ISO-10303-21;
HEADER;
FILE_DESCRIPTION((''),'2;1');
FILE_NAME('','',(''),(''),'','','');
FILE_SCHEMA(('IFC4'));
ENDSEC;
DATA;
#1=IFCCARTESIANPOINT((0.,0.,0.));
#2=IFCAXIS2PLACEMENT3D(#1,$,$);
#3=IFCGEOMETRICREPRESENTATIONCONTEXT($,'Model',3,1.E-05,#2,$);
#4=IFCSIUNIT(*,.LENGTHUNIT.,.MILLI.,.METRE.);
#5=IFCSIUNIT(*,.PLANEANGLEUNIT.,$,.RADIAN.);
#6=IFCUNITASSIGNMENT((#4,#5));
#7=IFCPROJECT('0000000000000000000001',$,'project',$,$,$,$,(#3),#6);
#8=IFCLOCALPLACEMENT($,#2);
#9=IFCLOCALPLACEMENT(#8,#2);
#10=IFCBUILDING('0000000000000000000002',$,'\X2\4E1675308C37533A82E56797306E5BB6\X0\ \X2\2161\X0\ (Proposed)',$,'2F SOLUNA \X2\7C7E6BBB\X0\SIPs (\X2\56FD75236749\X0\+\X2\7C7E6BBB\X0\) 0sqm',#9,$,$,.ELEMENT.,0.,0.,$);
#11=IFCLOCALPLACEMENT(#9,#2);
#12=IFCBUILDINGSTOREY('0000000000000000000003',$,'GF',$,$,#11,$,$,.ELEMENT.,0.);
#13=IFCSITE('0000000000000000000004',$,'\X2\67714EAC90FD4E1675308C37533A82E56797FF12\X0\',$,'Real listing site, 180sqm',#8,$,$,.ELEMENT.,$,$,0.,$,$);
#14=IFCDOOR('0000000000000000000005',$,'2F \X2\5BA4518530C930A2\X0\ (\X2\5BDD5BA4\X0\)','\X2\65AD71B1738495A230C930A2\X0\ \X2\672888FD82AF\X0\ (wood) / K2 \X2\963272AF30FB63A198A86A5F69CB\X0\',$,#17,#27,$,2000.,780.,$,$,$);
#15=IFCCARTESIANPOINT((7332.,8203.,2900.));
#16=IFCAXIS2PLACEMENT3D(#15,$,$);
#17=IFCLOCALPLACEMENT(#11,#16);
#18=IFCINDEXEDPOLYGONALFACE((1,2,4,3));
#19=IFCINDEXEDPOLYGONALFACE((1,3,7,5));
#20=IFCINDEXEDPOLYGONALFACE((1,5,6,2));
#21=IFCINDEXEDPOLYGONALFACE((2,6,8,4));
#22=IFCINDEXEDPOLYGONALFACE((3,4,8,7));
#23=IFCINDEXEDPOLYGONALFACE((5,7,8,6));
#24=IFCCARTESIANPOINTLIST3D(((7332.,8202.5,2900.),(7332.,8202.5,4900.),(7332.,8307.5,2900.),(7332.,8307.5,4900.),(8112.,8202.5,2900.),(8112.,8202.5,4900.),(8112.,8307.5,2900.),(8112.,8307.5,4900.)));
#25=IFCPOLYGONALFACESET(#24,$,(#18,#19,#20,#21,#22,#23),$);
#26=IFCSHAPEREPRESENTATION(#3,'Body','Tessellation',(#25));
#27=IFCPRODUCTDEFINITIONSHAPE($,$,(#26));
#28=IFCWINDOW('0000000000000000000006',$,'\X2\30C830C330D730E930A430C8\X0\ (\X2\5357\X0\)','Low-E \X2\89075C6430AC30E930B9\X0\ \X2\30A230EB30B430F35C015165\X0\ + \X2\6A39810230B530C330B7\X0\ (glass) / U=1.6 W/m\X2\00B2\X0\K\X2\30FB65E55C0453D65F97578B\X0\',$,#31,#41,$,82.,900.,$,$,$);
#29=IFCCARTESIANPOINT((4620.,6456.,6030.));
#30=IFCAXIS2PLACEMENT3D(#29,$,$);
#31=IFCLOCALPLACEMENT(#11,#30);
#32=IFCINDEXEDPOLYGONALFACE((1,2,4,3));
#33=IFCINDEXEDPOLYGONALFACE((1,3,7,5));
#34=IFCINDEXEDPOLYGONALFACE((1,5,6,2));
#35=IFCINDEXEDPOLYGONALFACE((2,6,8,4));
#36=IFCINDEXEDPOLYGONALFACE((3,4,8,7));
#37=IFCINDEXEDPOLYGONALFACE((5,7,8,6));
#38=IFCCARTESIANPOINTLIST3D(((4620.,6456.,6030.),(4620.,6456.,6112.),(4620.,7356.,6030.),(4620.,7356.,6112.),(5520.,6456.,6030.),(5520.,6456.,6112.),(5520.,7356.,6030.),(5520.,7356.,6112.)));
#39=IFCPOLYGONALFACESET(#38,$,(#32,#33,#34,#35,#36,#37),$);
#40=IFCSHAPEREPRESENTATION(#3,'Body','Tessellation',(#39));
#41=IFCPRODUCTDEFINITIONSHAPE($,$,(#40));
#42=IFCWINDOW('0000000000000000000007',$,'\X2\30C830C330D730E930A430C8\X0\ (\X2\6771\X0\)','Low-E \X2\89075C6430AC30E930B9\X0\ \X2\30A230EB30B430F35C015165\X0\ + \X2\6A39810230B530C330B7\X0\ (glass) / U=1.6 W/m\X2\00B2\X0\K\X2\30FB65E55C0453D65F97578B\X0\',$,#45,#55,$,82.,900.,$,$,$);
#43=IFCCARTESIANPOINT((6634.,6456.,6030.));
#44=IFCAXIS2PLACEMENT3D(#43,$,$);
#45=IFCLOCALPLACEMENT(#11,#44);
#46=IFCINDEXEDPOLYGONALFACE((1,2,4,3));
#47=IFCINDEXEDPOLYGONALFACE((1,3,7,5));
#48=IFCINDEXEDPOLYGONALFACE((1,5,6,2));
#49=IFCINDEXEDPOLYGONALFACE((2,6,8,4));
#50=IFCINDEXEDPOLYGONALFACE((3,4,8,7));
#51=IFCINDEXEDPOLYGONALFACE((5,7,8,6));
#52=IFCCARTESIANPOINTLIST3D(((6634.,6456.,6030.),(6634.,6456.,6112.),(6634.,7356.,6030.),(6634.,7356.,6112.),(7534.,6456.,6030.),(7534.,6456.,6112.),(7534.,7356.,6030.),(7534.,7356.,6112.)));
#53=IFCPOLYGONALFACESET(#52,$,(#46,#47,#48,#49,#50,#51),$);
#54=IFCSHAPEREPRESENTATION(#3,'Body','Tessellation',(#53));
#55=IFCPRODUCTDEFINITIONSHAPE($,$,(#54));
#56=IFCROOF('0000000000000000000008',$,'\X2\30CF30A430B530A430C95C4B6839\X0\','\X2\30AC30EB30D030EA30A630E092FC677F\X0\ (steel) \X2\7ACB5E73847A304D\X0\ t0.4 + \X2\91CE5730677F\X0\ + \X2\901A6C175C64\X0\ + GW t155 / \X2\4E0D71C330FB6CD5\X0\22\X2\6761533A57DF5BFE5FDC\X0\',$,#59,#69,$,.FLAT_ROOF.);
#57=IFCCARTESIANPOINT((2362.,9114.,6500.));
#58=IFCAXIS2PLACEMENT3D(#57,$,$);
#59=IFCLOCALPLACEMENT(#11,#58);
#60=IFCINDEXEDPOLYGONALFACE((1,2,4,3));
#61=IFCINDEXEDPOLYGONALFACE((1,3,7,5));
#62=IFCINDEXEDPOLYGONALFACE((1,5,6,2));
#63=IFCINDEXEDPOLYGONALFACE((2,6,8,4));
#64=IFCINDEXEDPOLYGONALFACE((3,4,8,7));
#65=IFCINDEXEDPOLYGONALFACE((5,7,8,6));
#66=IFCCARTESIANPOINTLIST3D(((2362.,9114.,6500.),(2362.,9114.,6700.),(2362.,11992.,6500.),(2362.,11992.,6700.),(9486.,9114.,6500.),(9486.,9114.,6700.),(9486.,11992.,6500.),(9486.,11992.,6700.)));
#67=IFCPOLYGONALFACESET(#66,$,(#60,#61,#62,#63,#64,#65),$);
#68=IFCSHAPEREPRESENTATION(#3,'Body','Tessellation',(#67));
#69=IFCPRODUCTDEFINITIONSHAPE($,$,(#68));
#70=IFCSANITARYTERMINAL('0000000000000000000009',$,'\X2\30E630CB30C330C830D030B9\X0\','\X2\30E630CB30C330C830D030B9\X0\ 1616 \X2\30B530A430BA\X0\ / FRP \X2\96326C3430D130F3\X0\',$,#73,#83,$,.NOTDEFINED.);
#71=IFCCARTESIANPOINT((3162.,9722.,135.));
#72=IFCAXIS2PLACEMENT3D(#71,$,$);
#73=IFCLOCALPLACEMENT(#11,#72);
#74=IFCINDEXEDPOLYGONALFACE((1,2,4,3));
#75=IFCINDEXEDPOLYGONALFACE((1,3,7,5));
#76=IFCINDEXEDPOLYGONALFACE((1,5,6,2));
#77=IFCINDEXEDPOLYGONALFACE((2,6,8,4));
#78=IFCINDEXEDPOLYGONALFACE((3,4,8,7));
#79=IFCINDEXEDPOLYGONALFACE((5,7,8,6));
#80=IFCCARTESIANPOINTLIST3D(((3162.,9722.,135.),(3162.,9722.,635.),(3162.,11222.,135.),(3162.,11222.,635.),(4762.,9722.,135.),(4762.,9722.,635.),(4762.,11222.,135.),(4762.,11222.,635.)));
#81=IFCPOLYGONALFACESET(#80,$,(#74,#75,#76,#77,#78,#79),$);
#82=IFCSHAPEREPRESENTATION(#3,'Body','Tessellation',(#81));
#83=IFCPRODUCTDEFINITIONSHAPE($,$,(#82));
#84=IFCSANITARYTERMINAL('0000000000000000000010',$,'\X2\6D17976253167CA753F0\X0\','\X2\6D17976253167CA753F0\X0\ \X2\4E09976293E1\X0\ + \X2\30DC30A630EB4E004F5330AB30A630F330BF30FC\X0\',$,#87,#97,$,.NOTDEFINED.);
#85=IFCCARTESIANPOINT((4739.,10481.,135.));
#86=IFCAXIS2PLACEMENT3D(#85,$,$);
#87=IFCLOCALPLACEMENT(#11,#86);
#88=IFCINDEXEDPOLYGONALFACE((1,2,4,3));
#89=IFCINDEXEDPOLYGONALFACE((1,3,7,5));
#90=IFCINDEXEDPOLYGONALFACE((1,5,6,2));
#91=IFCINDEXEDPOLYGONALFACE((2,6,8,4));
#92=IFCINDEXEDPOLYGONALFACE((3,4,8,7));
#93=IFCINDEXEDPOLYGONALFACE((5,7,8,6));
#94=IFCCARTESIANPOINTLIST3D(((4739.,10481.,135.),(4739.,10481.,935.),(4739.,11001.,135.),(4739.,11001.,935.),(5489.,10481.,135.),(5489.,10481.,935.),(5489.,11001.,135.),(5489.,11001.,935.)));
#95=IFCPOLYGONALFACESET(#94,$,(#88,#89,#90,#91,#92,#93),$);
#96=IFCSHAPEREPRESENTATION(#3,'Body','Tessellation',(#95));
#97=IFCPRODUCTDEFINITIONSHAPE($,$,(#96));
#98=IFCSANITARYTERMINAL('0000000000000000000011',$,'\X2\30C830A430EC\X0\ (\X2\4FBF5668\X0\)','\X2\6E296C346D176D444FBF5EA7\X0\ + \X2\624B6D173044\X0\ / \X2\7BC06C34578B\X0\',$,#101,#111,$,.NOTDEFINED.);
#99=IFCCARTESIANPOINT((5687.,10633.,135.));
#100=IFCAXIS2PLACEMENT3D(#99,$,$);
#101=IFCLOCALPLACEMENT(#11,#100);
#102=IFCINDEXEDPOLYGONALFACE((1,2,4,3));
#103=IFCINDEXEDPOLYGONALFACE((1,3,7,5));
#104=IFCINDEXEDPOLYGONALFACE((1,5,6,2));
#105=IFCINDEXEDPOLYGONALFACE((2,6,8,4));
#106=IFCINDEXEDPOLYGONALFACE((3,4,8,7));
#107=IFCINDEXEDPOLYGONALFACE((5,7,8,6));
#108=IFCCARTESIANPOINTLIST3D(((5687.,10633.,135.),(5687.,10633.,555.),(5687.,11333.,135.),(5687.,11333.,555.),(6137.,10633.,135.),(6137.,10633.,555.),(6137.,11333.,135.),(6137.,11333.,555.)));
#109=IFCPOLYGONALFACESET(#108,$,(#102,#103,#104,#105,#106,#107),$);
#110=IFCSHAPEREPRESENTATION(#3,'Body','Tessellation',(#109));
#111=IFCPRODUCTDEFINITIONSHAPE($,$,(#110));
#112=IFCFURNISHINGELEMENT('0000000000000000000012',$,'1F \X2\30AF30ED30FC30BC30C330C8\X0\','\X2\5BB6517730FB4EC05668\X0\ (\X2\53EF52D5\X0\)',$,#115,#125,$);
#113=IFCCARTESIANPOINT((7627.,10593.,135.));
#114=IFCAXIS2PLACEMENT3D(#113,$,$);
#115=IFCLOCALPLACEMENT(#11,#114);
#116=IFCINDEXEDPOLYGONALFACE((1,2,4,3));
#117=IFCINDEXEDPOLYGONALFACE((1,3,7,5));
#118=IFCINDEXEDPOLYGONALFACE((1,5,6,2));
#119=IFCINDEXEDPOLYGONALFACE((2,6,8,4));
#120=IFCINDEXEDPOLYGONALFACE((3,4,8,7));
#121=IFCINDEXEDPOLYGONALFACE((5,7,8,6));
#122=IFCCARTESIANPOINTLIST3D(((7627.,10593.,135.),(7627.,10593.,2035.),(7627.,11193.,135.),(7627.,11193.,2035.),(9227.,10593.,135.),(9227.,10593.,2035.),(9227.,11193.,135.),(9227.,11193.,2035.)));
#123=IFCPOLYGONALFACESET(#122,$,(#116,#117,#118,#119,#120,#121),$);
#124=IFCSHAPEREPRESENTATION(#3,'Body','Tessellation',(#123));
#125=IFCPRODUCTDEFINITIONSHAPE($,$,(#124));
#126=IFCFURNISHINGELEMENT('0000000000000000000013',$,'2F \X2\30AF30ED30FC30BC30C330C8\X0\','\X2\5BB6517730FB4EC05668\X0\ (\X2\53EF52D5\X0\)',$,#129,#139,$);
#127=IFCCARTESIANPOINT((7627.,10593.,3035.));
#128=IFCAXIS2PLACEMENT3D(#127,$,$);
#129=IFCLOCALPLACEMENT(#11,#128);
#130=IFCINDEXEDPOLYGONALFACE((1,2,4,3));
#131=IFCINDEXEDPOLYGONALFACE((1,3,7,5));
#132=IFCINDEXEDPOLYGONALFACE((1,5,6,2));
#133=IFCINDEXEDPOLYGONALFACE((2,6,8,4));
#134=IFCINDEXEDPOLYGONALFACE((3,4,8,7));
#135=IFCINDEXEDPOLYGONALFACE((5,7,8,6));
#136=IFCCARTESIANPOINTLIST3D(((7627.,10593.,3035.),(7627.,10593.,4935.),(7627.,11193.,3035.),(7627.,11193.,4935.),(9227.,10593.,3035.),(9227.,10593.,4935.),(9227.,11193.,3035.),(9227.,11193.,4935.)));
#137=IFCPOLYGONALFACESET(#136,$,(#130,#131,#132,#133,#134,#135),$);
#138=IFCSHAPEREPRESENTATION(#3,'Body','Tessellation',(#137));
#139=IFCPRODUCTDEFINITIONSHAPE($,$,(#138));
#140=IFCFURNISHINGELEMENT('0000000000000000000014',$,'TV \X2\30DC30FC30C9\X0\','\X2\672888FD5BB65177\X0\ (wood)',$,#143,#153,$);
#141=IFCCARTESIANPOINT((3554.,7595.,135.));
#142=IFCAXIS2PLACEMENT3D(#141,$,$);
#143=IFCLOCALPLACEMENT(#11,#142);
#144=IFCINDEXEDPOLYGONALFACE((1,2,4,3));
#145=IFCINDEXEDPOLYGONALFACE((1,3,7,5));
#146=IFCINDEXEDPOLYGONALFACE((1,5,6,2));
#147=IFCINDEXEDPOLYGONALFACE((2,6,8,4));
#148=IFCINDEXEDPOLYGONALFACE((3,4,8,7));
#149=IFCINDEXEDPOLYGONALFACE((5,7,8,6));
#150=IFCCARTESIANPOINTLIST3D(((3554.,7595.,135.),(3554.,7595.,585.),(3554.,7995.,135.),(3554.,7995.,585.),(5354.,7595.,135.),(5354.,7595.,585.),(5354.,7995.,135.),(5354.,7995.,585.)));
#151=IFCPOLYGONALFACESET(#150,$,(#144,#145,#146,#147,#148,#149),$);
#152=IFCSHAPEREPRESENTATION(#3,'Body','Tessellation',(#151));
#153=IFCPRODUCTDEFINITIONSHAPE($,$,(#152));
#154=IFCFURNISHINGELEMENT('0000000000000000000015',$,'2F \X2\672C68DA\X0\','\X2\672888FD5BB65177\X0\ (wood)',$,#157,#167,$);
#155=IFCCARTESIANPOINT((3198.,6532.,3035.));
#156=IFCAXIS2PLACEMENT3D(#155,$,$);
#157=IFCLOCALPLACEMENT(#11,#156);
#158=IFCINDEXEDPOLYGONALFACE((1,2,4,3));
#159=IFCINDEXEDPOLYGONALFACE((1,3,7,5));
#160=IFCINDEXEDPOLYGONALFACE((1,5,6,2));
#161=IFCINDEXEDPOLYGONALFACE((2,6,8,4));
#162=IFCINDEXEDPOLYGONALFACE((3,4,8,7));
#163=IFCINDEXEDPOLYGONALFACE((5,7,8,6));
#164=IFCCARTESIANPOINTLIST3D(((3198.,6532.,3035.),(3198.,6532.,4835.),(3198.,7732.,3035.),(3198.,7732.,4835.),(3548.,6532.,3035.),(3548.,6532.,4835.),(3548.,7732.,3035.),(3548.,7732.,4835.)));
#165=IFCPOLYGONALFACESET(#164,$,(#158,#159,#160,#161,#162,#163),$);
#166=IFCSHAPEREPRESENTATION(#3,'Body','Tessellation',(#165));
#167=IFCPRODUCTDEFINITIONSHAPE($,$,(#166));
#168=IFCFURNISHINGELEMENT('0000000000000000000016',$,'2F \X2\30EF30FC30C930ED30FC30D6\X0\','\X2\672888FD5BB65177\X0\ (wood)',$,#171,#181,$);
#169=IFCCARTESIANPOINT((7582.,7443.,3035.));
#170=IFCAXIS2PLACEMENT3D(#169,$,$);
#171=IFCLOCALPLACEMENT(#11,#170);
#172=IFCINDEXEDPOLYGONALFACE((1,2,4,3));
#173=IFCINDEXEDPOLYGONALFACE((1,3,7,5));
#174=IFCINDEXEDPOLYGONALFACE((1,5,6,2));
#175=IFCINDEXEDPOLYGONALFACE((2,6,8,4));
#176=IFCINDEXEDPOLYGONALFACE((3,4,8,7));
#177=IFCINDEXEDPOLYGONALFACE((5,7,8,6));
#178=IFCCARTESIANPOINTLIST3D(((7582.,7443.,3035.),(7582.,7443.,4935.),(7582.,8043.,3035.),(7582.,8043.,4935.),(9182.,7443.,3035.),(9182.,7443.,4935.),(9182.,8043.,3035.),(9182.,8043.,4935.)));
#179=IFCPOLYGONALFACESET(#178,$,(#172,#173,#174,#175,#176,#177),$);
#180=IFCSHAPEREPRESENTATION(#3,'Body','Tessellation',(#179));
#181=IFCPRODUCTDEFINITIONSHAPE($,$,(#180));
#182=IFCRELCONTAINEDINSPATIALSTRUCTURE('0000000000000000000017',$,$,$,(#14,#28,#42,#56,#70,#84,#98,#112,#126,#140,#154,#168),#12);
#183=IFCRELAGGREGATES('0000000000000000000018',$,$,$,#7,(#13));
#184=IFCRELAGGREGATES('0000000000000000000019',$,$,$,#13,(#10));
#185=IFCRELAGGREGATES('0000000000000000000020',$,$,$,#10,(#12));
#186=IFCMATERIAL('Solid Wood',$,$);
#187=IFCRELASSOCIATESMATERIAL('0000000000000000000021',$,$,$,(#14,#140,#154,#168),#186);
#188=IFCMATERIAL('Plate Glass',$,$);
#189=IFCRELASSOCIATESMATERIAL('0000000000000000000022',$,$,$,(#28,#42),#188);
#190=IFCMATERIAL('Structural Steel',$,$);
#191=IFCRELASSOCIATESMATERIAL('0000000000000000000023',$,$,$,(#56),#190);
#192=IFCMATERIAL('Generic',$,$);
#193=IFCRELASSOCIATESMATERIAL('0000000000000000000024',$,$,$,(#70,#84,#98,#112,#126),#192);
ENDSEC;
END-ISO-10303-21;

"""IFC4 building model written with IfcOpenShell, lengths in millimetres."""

from ifc_helpers import new_model, si_unit, frame, frame_2d, origin, place, context, project, spatial, rectangle, extrude, material, element, save


model = new_model("IFC4")

# Units and contexts
model_context = context("Model", 3, precision=1e-05, world=origin())
ifc_project = project(units=[si_unit("LENGTHUNIT", "METRE", prefix="MILLI"), si_unit("PLANEANGLEUNIT", "RADIAN")], contexts=[model_context])

# Site, building, storey
site_placement = place(None, origin())
site = spatial("IfcSite", under=ifc_project, at=site_placement, Name="東京都世田谷区若林２", ObjectType="Real listing site, 180sqm", CompositionType="ELEMENT", RefElevation=0.0)
building_placement = place(site_placement, origin())
building = spatial("IfcBuilding", under=site, at=building_placement, Name="世田谷区若林の家 Ⅱ (Proposed)", ObjectType="2F SOLUNA 籾殻SIPs (国産杉+籾殻) 0sqm", CompositionType="ELEMENT", ElevationOfRefHeight=0.0, ElevationOfTerrain=0.0)
storey_placement = place(building_placement, origin())
storey = spatial("IfcBuildingStorey", under=building, at=storey_placement, Name="GF", CompositionType="ELEMENT", Elevation=0.0)

# Shared definitions
ifc_material_1 = material(Name="Solid Wood")
ifc_material_2 = material(Name="Plate Glass")

# Door
door_1_placement = place(storey_placement, frame((7332.0, 8203.0, 2900.0)))
element("IfcDoor", 1, at=door_1_placement, inside=storey, material=ifc_material_1, Name="2F 室内ドア (寝室)", Description="断熱玄関ドア 木製芯 (wood) / K2 防犯・採風機構", OverallHeight=2000.0, OverallWidth=780.0, context=model_context, shape_type="SweptSolid", body=[
    extrude(rectangle(XDim=780.0, YDim=105.0, at=frame_2d((390.0, 52.0))), frame((7332.0, 8203.0, 2900.0)), (0.0, 0.0, 1.0), 2000.0),
])

# Windows
window_1_placement = place(storey_placement, frame((4620.0, 6456.0, 6030.0)))
element("IfcWindow", 2, at=window_1_placement, inside=storey, material=ifc_material_2, Name="トップライト (南)", Description="Low-E 複層ガラス アルゴン封入 + 樹脂サッシ (glass) / U=1.6 W/m²K・日射取得型", OverallHeight=82.0, OverallWidth=900.0, context=model_context, shape_type="SweptSolid", body=[
    extrude(rectangle(XDim=900.0, YDim=900.0, at=frame_2d((450.0, 450.0))), frame((4620.0, 6456.0, 6030.0)), (0.0, 0.0, 1.0), 82.0),
])
window_2_placement = place(storey_placement, frame((6634.0, 6456.0, 6030.0)))
element("IfcWindow", 3, at=window_2_placement, inside=storey, material=ifc_material_2, Name="トップライト (東)", Description="Low-E 複層ガラス アルゴン封入 + 樹脂サッシ (glass) / U=1.6 W/m²K・日射取得型", OverallHeight=82.0, OverallWidth=900.0, context=model_context, shape_type="SweptSolid", body=[
    extrude(rectangle(XDim=900.0, YDim=900.0, at=frame_2d((450.0, 450.0))), frame((6634.0, 6456.0, 6030.0)), (0.0, 0.0, 1.0), 82.0),
])

# Roof
ifc_material_3 = material(Name="Structural Steel")
roof_placement = place(storey_placement, frame((2362.0, 9114.0, 6500.0)))
element("IfcRoof", 4, at=roof_placement, inside=storey, material=ifc_material_3, Name="ハイサイド屋根", Description="ガルバリウム鋼板 (steel) 立平葺き t0.4 + 野地板 + 通気層 + GW t155 / 不燃・法22条区域対応", PredefinedType="FLAT_ROOF", context=model_context, shape_type="SweptSolid", body=[
    extrude(rectangle(XDim=7124.0, YDim=2878.0, at=frame_2d((3562.0, 1439.0))), frame((2362.0, 9114.0, 6500.0)), (0.0, 0.0, 1.0), 200.0),
])

# Sanitary terminals
ifc_material_4 = material(Name="Generic")
sanitary_terminal_1_placement = place(storey_placement, frame((3162.0, 9722.0, 135.0)))
element("IfcSanitaryTerminal", 5, at=sanitary_terminal_1_placement, inside=storey, material=ifc_material_4, Name="ユニットバス", Description="ユニットバス 1616 サイズ / FRP 防水パン", PredefinedType="NOTDEFINED", context=model_context, shape_type="SweptSolid", body=[
    extrude(rectangle(XDim=1600.0, YDim=1500.0, at=frame_2d((800.0, 750.0))), frame((3162.0, 9722.0, 135.0)), (0.0, 0.0, 1.0), 500.0),
])
sanitary_terminal_2_placement = place(storey_placement, frame((4739.0, 10481.0, 135.0)))
element("IfcSanitaryTerminal", 6, at=sanitary_terminal_2_placement, inside=storey, material=ifc_material_4, Name="洗面化粧台", Description="洗面化粧台 三面鏡 + ボウル一体カウンター", PredefinedType="NOTDEFINED", context=model_context, shape_type="SweptSolid", body=[
    extrude(rectangle(XDim=750.0, YDim=520.0, at=frame_2d((375.0, 260.0))), frame((4739.0, 10481.0, 135.0)), (0.0, 0.0, 1.0), 800.0),
])
sanitary_terminal_3_placement = place(storey_placement, frame((5687.0, 10633.0, 135.0)))
element("IfcSanitaryTerminal", 7, at=sanitary_terminal_3_placement, inside=storey, material=ifc_material_4, Name="トイレ (便器)", Description="温水洗浄便座 + 手洗い / 節水型", PredefinedType="NOTDEFINED", context=model_context, shape_type="SweptSolid", body=[
    extrude(rectangle(XDim=450.0, YDim=700.0, at=frame_2d((225.0, 350.0))), frame((5687.0, 10633.0, 135.0)), (0.0, 0.0, 1.0), 420.0),
])

# Furnishing elements
furnishing_1_placement = place(storey_placement, frame((7627.0, 10593.0, 135.0)))
element("IfcFurnishingElement", 8, at=furnishing_1_placement, inside=storey, material=ifc_material_4, Name="1F クローゼット", Description="家具・什器 (可動)", context=model_context, shape_type="SweptSolid", body=[
    extrude(rectangle(XDim=1600.0, YDim=600.0, at=frame_2d((800.0, 300.0))), frame((7627.0, 10593.0, 135.0)), (0.0, 0.0, 1.0), 1900.0),
])
furnishing_2_placement = place(storey_placement, frame((7627.0, 10593.0, 3035.0)))
element("IfcFurnishingElement", 9, at=furnishing_2_placement, inside=storey, material=ifc_material_4, Name="2F クローゼット", Description="家具・什器 (可動)", context=model_context, shape_type="SweptSolid", body=[
    extrude(rectangle(XDim=1600.0, YDim=600.0, at=frame_2d((800.0, 300.0))), frame((7627.0, 10593.0, 3035.0)), (0.0, 0.0, 1.0), 1900.0),
])
furnishing_3_placement = place(storey_placement, frame((3554.0, 7595.0, 135.0)))
element("IfcFurnishingElement", 10, at=furnishing_3_placement, inside=storey, material=ifc_material_1, Name="TV ボード", Description="木製家具 (wood)", context=model_context, shape_type="SweptSolid", body=[
    extrude(rectangle(XDim=1800.0, YDim=400.0, at=frame_2d((900.0, 200.0))), frame((3554.0, 7595.0, 135.0)), (0.0, 0.0, 1.0), 450.0),
])
furnishing_4_placement = place(storey_placement, frame((3198.0, 6532.0, 3035.0)))
element("IfcFurnishingElement", 11, at=furnishing_4_placement, inside=storey, material=ifc_material_1, Name="2F 本棚", Description="木製家具 (wood)", context=model_context, shape_type="SweptSolid", body=[
    extrude(rectangle(XDim=350.0, YDim=1200.0, at=frame_2d((175.0, 600.0))), frame((3198.0, 6532.0, 3035.0)), (0.0, 0.0, 1.0), 1800.0),
])
furnishing_5_placement = place(storey_placement, frame((7582.0, 7443.0, 3035.0)))
element("IfcFurnishingElement", 12, at=furnishing_5_placement, inside=storey, material=ifc_material_1, Name="2F ワードローブ", Description="木製家具 (wood)", context=model_context, shape_type="SweptSolid", body=[
    extrude(rectangle(XDim=1600.0, YDim=600.0, at=frame_2d((800.0, 300.0))), frame((7582.0, 7443.0, 3035.0)), (0.0, 0.0, 1.0), 1900.0),
])

save(model, "model.ifc")
